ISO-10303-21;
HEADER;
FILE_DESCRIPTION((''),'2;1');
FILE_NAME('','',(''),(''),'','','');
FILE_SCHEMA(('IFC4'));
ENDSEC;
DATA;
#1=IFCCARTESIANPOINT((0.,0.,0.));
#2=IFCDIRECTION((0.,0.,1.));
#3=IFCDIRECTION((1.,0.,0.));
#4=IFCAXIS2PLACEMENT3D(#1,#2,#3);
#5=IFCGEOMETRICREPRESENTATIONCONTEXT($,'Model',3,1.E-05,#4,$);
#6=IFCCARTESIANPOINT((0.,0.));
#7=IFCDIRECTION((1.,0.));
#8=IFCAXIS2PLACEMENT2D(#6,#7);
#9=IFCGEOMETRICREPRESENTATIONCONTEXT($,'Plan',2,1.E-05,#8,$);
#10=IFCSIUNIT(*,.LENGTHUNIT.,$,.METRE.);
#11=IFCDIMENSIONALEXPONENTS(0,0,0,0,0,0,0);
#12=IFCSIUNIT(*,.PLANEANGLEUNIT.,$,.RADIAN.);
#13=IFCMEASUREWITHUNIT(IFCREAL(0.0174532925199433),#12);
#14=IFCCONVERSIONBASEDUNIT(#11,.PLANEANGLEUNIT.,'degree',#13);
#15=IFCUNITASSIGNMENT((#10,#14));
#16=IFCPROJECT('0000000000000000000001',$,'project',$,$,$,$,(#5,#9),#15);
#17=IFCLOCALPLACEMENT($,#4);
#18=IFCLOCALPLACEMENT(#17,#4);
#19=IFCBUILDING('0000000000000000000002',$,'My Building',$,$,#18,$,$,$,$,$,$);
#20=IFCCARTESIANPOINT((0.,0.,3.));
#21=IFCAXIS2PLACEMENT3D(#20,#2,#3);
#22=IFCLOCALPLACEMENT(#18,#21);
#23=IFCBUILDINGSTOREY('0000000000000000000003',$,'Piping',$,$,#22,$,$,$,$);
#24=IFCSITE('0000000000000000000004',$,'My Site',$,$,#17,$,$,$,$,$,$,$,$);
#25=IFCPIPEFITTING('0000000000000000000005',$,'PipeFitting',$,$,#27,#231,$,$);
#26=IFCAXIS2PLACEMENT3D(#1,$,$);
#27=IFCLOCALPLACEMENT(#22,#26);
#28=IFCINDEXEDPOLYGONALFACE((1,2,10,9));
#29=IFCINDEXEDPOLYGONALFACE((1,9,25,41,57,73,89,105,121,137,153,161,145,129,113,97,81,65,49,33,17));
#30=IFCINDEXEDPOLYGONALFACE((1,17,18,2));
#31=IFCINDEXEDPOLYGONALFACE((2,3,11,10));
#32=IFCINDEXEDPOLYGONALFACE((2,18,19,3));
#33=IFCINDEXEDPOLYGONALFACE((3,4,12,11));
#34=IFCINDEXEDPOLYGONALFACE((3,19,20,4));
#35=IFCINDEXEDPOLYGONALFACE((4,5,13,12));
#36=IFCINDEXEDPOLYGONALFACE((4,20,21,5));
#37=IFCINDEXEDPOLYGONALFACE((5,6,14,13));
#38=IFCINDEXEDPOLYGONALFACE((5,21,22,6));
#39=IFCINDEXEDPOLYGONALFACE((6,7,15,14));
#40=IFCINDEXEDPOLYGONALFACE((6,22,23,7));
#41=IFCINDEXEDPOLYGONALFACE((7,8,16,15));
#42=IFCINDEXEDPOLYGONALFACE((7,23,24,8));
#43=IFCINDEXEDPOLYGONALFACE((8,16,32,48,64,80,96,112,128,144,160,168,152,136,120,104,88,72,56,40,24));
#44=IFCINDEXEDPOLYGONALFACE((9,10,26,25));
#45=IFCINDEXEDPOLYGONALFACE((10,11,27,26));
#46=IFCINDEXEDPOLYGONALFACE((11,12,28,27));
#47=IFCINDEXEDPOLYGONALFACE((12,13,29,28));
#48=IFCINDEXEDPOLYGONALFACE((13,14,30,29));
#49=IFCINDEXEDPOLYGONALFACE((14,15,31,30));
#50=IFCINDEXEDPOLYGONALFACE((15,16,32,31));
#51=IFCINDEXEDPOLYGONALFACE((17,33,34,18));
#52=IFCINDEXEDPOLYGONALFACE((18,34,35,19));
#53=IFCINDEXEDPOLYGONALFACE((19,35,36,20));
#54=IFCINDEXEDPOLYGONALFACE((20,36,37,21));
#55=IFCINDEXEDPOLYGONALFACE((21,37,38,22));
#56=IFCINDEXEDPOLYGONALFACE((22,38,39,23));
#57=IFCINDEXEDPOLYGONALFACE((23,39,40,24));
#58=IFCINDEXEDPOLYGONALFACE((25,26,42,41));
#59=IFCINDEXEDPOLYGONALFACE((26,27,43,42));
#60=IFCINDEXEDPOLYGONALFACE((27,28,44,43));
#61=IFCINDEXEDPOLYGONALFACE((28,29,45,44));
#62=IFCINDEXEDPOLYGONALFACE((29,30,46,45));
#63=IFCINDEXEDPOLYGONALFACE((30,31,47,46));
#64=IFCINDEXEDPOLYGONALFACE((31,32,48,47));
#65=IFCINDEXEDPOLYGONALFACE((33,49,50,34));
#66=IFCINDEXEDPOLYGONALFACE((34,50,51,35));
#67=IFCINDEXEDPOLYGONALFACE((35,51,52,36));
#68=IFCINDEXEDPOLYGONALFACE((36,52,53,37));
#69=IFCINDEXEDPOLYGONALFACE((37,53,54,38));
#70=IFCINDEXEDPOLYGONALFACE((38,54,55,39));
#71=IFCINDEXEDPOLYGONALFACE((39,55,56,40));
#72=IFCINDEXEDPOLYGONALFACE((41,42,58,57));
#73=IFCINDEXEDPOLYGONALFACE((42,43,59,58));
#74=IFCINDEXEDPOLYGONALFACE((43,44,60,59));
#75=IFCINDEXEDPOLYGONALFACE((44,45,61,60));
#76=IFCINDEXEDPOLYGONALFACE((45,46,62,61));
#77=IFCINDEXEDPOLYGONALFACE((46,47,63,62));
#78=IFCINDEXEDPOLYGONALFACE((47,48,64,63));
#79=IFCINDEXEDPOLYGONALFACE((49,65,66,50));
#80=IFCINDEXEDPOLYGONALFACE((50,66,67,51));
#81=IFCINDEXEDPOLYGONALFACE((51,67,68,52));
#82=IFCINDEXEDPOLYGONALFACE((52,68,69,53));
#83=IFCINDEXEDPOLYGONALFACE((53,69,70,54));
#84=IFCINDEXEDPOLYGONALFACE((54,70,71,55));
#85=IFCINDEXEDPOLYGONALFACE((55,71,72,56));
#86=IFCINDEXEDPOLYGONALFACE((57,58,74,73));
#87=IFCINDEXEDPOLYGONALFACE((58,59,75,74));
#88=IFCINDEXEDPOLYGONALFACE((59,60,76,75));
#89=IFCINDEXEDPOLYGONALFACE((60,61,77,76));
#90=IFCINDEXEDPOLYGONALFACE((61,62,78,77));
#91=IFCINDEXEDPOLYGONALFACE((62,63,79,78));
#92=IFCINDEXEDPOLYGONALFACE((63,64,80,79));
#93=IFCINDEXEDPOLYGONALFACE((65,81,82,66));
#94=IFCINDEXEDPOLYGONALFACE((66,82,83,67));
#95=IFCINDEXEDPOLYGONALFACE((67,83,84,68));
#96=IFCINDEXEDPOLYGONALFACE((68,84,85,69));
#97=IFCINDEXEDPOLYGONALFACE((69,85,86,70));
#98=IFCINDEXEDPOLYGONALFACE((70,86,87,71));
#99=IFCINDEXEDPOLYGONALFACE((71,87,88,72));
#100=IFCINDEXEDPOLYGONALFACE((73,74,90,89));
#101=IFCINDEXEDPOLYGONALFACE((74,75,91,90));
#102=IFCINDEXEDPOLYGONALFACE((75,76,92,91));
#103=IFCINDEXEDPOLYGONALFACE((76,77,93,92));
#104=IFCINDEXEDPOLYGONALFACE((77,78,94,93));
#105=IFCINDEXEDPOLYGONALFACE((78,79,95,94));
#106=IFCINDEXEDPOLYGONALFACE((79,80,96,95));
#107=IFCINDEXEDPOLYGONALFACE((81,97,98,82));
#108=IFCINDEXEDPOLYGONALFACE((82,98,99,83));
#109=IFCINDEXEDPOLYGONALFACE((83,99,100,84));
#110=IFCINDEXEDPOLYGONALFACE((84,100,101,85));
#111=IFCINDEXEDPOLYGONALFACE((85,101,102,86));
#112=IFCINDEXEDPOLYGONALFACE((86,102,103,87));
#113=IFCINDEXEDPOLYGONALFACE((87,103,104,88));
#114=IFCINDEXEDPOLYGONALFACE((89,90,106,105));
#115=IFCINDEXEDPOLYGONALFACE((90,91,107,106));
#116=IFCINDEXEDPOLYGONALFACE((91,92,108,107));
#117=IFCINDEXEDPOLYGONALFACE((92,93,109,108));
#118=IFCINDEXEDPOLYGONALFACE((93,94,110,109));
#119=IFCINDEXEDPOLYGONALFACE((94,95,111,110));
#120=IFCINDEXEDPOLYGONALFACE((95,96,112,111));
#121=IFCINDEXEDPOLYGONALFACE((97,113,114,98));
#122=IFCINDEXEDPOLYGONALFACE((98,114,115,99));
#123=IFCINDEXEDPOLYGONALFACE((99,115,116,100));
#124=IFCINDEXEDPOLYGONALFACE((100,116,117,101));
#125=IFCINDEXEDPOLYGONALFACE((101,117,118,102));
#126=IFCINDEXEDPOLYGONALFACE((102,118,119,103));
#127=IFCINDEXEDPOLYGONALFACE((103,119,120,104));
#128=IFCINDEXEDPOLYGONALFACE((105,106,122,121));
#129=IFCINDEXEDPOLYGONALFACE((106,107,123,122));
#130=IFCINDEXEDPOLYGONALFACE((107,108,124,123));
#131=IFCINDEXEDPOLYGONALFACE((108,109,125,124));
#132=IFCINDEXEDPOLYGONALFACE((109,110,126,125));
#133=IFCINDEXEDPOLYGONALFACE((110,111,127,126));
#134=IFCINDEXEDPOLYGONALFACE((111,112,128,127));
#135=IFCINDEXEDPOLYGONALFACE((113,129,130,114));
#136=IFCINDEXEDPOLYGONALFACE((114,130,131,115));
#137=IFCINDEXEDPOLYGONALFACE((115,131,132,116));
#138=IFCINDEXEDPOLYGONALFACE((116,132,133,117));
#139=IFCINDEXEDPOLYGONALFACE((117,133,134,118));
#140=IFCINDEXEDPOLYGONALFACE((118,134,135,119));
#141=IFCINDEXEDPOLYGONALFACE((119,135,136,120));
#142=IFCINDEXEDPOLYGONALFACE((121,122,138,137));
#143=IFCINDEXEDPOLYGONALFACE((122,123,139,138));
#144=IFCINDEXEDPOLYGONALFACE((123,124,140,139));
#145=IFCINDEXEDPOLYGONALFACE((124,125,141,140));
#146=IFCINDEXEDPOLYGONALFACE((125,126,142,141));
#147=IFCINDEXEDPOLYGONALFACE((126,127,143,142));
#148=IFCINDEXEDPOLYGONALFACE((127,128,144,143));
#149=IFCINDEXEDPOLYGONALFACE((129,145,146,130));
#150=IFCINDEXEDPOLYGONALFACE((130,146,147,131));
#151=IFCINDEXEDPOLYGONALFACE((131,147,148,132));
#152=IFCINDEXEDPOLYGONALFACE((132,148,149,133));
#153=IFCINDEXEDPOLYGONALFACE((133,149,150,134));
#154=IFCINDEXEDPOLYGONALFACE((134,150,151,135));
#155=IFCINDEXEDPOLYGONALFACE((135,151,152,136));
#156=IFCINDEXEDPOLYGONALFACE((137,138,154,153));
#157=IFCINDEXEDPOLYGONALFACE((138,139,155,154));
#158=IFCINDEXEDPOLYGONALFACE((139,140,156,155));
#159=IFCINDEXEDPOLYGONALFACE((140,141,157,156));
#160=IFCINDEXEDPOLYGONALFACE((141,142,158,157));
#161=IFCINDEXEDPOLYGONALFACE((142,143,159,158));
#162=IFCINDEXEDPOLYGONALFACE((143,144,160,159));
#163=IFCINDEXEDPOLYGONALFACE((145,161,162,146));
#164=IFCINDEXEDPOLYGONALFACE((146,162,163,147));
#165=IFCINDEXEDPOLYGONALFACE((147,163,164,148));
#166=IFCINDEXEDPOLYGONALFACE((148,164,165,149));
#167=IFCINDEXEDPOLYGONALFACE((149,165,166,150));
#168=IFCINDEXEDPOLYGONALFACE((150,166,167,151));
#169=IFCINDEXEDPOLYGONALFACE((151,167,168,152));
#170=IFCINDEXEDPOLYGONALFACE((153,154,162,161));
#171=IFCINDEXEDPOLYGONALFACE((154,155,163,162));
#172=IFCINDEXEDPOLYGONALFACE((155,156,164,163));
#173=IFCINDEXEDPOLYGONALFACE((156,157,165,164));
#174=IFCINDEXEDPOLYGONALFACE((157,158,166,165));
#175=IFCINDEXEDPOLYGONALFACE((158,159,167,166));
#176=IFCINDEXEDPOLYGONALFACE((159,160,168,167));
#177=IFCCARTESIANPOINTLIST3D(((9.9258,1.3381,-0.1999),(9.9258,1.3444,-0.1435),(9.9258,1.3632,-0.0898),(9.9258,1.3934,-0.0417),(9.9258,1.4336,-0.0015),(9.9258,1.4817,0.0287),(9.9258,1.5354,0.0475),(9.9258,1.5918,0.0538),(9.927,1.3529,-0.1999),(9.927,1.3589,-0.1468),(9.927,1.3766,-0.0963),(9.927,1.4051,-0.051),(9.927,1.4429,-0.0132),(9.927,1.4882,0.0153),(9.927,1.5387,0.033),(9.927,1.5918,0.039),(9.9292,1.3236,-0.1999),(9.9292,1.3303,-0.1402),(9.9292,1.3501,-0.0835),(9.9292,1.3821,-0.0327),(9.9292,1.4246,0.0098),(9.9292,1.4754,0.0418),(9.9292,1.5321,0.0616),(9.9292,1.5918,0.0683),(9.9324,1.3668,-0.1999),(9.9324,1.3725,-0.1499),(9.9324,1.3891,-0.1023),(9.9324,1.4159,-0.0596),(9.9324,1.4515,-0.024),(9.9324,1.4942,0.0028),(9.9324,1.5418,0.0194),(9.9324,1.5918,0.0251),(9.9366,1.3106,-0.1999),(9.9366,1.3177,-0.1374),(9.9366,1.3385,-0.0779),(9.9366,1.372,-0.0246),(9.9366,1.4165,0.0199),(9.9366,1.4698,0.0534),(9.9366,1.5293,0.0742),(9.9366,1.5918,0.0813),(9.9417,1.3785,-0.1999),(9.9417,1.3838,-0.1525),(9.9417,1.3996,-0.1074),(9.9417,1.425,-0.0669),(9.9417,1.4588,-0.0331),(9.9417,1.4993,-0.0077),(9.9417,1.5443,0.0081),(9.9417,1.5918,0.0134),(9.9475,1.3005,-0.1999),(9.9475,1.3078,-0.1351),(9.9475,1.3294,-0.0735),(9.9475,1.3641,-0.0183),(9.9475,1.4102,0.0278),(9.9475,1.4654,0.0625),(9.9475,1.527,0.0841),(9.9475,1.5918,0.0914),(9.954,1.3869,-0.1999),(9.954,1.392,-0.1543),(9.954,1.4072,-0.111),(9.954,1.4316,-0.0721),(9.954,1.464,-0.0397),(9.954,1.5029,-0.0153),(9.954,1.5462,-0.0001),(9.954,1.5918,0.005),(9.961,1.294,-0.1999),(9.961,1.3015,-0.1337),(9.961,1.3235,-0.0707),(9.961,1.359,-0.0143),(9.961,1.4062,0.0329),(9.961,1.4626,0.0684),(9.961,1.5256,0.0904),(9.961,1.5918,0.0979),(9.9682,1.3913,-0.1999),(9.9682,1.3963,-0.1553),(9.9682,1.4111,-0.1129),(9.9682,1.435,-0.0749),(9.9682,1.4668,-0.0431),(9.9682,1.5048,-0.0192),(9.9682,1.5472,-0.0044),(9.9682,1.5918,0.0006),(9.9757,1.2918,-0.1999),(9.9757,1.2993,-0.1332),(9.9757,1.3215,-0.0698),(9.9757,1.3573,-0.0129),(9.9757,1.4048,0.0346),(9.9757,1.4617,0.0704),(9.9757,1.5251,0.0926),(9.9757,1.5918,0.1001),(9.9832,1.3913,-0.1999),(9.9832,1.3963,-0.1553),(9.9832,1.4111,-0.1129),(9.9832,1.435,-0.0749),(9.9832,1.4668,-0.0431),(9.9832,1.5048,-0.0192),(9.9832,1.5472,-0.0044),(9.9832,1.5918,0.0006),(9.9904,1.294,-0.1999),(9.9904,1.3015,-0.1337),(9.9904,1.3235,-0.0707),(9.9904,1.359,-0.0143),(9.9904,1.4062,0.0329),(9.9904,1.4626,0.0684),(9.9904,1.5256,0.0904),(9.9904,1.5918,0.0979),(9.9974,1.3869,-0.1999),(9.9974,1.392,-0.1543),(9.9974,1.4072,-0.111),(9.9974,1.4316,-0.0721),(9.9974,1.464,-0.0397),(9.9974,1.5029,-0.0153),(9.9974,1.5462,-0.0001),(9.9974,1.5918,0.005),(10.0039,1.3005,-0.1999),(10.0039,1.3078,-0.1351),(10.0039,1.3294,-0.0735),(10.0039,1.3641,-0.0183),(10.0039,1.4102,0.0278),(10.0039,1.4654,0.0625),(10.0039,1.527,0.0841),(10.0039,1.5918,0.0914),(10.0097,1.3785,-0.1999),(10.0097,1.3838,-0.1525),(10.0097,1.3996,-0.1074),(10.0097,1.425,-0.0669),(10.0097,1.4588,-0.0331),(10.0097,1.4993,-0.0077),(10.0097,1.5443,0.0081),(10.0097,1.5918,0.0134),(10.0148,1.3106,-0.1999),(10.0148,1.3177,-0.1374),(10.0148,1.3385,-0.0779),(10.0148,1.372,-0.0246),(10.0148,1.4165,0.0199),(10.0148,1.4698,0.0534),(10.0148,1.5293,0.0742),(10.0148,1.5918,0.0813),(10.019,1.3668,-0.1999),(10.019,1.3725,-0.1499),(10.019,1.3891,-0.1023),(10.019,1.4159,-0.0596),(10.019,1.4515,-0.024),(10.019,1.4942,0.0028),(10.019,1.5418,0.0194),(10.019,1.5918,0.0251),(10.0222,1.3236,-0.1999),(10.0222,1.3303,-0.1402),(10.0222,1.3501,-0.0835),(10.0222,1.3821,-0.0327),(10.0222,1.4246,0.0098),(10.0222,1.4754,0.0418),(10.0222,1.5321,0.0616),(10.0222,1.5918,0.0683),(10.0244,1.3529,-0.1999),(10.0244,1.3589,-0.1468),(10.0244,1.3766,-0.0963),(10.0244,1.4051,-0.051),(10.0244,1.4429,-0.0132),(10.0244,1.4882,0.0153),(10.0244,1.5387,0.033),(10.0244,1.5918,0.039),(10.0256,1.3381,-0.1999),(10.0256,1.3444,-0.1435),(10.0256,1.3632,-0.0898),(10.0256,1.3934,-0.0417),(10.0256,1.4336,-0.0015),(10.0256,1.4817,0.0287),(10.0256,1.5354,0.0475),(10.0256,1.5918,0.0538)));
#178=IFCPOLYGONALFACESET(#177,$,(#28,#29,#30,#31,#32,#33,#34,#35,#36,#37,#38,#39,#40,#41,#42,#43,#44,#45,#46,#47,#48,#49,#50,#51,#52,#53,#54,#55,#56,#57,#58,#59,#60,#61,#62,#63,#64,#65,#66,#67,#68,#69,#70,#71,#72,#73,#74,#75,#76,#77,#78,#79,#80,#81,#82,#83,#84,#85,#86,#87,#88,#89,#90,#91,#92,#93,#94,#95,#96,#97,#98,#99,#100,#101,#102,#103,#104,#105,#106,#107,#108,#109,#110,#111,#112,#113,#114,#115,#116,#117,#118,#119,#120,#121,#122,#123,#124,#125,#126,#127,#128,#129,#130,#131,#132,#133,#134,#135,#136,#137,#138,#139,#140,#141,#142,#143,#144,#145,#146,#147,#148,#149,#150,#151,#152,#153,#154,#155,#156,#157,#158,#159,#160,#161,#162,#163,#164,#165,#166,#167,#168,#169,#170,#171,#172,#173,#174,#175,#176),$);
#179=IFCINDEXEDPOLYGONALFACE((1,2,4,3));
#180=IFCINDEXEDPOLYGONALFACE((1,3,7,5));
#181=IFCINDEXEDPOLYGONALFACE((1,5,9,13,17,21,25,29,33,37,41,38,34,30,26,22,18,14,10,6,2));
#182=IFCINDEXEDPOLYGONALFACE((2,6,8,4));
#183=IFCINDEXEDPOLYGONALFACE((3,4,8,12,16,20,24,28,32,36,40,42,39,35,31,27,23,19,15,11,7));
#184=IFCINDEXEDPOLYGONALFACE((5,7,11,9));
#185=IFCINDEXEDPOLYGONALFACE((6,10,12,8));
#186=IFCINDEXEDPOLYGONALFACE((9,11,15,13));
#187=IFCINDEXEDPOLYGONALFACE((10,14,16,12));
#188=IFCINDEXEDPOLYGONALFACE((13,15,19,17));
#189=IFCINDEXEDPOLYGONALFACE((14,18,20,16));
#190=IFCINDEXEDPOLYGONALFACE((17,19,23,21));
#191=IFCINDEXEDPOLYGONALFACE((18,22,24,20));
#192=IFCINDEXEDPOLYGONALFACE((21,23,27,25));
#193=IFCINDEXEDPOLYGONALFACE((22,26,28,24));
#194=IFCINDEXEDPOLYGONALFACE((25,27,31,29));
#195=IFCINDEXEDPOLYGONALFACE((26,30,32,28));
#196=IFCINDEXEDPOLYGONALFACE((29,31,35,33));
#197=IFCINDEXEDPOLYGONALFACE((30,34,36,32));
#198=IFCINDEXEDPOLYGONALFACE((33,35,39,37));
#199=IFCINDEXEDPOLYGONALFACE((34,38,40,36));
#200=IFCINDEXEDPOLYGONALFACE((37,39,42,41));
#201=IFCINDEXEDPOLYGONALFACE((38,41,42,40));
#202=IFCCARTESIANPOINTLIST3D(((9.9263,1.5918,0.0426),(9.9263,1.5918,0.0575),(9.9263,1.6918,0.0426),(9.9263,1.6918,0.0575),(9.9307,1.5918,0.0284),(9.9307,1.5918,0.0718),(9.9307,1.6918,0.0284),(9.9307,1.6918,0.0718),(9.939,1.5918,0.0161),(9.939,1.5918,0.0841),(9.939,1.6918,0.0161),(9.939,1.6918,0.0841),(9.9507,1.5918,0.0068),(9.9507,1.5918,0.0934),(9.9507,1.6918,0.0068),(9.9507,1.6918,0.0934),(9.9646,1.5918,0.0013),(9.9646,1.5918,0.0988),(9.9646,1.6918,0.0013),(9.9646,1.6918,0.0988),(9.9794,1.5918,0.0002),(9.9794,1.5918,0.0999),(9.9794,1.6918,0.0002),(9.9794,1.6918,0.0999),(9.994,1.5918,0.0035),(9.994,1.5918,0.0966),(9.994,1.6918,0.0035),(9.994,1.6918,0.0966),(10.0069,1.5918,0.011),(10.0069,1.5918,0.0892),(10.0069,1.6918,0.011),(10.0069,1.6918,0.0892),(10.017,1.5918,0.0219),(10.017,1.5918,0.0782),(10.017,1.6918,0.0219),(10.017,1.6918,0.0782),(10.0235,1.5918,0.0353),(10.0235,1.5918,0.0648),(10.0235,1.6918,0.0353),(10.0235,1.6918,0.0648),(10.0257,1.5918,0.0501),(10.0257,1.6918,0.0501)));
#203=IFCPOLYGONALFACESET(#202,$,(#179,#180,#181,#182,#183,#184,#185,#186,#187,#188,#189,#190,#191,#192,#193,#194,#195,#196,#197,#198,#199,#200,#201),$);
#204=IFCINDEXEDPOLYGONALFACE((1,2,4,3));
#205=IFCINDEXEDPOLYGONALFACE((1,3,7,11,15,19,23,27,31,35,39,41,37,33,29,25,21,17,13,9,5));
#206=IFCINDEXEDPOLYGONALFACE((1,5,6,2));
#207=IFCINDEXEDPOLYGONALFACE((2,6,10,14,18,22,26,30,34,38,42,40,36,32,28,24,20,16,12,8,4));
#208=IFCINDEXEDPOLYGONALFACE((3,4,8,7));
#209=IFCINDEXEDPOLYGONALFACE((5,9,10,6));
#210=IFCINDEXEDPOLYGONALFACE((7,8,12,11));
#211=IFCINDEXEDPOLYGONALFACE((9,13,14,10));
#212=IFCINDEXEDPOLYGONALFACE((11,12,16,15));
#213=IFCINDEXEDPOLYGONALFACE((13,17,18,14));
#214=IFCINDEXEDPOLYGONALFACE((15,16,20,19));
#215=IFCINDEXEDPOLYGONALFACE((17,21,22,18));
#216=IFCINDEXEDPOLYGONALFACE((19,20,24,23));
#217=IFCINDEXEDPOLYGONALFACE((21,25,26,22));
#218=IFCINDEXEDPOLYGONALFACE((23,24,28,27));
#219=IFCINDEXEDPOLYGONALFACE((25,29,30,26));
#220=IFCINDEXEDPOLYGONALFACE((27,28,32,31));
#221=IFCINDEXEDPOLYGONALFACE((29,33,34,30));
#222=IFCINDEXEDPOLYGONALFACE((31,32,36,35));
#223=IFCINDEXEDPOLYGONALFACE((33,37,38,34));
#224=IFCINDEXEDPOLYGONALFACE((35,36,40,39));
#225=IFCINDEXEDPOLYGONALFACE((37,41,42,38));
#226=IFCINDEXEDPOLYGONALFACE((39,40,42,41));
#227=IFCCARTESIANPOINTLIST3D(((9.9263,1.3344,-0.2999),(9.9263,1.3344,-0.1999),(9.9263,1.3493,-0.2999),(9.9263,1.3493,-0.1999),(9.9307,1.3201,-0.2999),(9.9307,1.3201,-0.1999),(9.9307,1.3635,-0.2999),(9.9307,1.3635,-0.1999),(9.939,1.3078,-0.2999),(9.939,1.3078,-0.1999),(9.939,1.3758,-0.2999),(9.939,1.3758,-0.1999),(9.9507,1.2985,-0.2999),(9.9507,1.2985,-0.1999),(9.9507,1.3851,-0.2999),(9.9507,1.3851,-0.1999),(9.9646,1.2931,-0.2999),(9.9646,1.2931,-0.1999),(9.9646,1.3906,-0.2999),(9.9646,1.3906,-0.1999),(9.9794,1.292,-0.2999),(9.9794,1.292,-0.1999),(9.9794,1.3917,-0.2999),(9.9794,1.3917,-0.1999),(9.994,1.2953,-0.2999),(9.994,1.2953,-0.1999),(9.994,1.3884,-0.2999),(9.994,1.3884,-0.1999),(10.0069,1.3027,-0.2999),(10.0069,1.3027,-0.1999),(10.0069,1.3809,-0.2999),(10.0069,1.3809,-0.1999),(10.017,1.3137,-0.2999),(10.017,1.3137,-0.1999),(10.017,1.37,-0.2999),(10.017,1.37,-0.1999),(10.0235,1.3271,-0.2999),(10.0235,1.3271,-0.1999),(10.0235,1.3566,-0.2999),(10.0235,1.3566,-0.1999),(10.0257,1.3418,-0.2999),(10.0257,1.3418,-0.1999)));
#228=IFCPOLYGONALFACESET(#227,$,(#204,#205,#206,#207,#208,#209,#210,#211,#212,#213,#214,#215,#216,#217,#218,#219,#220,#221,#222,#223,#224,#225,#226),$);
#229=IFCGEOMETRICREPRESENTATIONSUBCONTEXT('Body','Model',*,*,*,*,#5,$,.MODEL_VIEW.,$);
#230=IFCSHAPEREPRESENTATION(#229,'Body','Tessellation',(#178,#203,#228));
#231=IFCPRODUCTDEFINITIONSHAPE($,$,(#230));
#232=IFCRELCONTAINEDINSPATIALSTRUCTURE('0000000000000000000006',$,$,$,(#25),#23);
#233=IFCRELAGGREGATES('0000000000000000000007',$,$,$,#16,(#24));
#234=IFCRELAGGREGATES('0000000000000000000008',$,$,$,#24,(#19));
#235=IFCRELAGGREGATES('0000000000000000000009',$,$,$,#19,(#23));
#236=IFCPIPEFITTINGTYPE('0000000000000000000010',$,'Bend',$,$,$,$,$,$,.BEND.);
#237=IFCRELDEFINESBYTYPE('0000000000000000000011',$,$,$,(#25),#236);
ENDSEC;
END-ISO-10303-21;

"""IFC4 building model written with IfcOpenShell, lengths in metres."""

from ifc_helpers import new_model, entity, si_unit, converted_unit, frame, origin_with_axes, origin_2d_with_axis, place, context, subcontext, project, spatial, circle, extrude, source, transform, mapped, type_object, type_shapes, element, save


model = new_model("IFC4")

# Units and contexts
model_context = context("Model", 3, precision=1e-05, world=origin_with_axes())
plan_context = context("Plan", 2, precision=1e-05, world=origin_2d_with_axis())
body_context = subcontext(model_context, "Body", "Model", "MODEL_VIEW")
ifc_project = project(units=[si_unit("LENGTHUNIT", "METRE"), converted_unit("PLANEANGLEUNIT", "degree", entity("IfcReal", 0.0174532925199433), si_unit("PLANEANGLEUNIT", "RADIAN"), dimensions=[0, 0, 0, 0, 0, 0, 0])], contexts=[model_context, plan_context])

# Site, building, storey
site_placement = place(None, origin_with_axes())
site = spatial("IfcSite", under=ifc_project, at=site_placement, Name="My Site")
building_placement = place(site_placement, origin_with_axes())
building = spatial("IfcBuilding", under=site, at=building_placement, Name="My Building")
storey_placement = place(building_placement, frame((0.0, 0.0, 3.0), z_axis=(0.0, 0.0, 1.0), x_axis=(1.0, 0.0, 0.0)))
storey = spatial("IfcBuildingStorey", under=building, at=storey_placement, Name="Piping")

# Pipe fitting
pipe_fitting_type_1 = type_object("IfcPipeFittingType", Name="Bend", PredefinedType="BEND")
shared_shape = source(origin_with_axes(), body_context, "Body", "SolidModel", [
    entity("IfcSweptDiskSolid", entity("IfcIndexedPolyCurve", entity("IfcCartesianPointList3D", [[0.0, 0.0, 0.1], [0.0, -0.0732, 0.2768], [0.0, -0.25, 0.35]]), [entity("IfcArcIndex", [1, 2, 3])]), 0.05),
    extrude(circle(Radius=0.05), origin_with_axes(), (0.0, 0.0, 1.0), 0.1),
    extrude(circle(Radius=0.05), frame((0.0, -0.25, 0.35), z_axis=(0.0, -1.0, -0.000003), x_axis=(1.0, 0.0, 0.0)), (0.0, 0.0, 1.0), 0.1),
])
type_shapes(pipe_fitting_type_1, [shared_shape])
for number, where, z_axis, x_axis, name in (
    (1, (9.9757, 1.6918, 0.0501), (0.0, -1.0, 0.0), (1.0, 0.0, 0.0), "PipeFitting"),
):
    element("IfcPipeFitting", number, at=place(storey_placement, frame(where, z_axis=z_axis, x_axis=x_axis)), inside=storey, type_object=pipe_fitting_type_1, Name=name, context=body_context, shape_type="MappedRepresentation", body=[
        mapped(shared_shape, transform((0.0, 0.0, 0.0), x_axis=(1.0, 0.0, 0.0), y_axis=(0.0, 1.0, 0.0), z_axis=(0.0, 0.0, 1.0), scale=1.0)),
    ])

save(model, "model.ifc")
